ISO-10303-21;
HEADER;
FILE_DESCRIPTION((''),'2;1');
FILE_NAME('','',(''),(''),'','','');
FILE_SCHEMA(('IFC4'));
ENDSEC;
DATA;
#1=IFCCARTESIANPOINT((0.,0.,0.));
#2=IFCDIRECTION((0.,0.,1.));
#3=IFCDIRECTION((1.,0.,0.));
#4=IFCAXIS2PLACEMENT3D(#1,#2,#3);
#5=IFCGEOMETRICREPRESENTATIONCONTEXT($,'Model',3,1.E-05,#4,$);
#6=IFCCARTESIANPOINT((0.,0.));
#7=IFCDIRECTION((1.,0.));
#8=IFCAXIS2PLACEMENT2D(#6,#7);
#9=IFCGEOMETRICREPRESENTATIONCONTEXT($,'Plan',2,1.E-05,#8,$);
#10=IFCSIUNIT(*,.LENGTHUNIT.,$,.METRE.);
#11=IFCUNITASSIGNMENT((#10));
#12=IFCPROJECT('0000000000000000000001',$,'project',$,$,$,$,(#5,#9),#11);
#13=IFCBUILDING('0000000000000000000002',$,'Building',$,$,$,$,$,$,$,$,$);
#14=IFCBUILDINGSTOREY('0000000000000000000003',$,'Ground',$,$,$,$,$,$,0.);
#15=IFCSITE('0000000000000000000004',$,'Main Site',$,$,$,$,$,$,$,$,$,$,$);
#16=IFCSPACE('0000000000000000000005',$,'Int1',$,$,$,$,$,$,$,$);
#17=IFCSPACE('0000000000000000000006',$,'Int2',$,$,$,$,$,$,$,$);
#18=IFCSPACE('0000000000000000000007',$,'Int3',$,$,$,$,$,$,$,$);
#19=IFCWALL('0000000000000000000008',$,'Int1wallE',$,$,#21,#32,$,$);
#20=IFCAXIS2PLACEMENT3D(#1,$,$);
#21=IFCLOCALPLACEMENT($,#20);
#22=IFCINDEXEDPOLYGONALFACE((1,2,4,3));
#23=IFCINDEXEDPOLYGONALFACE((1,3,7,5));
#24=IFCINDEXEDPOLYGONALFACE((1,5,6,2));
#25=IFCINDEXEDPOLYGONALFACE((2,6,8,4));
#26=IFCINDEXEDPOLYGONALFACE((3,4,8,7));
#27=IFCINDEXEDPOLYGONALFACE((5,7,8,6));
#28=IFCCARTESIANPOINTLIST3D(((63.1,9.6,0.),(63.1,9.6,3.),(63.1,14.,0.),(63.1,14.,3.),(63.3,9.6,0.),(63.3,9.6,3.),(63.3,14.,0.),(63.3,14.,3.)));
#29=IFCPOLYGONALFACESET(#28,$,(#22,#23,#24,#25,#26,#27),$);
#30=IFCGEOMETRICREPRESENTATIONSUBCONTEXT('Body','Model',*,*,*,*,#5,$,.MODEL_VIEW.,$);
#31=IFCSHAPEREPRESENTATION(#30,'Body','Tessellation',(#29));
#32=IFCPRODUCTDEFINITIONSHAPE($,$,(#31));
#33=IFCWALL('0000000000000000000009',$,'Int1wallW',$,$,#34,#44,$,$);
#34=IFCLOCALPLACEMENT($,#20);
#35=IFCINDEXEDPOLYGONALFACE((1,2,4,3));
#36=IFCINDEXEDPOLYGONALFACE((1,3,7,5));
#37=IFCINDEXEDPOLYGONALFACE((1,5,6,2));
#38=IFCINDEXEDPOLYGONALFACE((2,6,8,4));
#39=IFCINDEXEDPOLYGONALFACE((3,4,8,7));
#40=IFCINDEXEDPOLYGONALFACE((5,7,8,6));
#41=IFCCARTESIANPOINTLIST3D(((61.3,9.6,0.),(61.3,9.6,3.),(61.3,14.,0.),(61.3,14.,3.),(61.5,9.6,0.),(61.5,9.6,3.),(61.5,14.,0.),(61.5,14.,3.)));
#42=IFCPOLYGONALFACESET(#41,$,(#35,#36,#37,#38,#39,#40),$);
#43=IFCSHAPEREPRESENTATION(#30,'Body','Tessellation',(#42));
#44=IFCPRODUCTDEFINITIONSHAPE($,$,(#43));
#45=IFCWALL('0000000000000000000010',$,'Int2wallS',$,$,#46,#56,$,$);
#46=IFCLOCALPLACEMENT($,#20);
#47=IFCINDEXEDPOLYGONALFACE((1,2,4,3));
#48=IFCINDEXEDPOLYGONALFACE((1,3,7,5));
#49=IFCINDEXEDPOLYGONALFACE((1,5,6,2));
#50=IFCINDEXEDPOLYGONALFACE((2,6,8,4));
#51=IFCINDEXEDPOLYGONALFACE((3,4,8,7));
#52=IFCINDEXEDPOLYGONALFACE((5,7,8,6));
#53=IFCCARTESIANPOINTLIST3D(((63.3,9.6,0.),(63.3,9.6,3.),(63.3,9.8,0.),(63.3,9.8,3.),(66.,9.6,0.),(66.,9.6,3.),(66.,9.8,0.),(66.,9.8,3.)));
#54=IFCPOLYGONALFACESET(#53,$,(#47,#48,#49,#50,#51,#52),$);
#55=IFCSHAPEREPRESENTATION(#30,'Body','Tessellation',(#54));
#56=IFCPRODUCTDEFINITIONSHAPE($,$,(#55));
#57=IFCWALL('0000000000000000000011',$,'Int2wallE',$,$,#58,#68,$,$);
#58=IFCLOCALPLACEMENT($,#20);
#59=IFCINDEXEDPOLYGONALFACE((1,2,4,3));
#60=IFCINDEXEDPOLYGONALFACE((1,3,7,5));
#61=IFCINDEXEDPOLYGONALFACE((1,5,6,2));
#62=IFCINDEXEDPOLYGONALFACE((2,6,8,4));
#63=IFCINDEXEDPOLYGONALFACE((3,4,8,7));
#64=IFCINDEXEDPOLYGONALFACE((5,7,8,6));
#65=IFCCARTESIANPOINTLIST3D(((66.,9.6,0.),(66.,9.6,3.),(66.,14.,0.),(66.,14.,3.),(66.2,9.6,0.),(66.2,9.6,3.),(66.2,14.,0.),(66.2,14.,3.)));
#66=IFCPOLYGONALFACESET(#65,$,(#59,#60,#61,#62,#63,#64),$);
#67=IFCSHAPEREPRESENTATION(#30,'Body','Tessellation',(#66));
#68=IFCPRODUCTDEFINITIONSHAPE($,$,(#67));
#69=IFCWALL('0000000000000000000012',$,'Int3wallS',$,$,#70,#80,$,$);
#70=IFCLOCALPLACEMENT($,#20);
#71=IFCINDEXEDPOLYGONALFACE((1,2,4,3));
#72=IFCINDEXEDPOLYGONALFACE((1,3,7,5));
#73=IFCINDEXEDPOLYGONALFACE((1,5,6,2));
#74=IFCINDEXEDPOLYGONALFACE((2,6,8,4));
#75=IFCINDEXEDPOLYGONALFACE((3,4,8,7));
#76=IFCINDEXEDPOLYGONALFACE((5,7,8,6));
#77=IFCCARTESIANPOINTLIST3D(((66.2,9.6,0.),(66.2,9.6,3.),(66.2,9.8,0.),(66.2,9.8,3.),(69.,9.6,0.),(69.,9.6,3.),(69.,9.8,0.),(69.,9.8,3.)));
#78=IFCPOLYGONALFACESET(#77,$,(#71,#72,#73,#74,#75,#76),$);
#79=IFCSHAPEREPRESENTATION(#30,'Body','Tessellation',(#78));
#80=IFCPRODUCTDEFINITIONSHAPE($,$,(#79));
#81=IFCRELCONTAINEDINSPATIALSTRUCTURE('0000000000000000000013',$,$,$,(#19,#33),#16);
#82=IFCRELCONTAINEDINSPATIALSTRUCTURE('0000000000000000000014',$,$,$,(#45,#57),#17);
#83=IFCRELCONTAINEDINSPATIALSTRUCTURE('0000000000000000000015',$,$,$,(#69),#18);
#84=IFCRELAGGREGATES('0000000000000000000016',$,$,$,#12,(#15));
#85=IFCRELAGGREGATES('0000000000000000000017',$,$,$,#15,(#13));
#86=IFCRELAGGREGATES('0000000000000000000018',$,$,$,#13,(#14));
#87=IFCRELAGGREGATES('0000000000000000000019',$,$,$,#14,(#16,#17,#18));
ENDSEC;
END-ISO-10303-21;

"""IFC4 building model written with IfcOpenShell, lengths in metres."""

from ifc_helpers import new_model, si_unit, frame, origin_with_axes, origin_2d_with_axis, place, context, subcontext, project, spatial, indexed_curve, outline, extrude, element, save


model = new_model("IFC4")

# Units and contexts
model_context = context("Model", 3, precision=1e-05, world=origin_with_axes())
plan_context = context("Plan", 2, precision=1e-05, world=origin_2d_with_axis())
body_context = subcontext(model_context, "Body", "Model", "MODEL_VIEW")
ifc_project = project(units=[si_unit("LENGTHUNIT", "METRE")], contexts=[model_context, plan_context])

# Site, building, storey
site = spatial("IfcSite", under=ifc_project, Name="Main Site")
building = spatial("IfcBuilding", under=site, Name="Building")
storey = spatial("IfcBuildingStorey", under=building, Name="Ground", Elevation=0.0)

# Shared definitions
space_1 = spatial("IfcSpace", under=storey, Name="Int1")

# Walls
for number, where, z_axis, x_axis, name in (
    (1, (63.3, 9.6, 0.0), (0.0, 0.0, 1.0), (0.0, 1.0, 0.0), "Int1wallE"),
    (2, (61.5, 9.6, 0.0), (0.0, 0.0, 1.0), (0.0, 1.0, 0.0), "Int1wallW"),
):
    element("IfcWall", number, at=place(None, frame(where, z_axis=z_axis, x_axis=x_axis)), inside=space_1, Name=name, context=body_context, shape_type="SweptSolid", body=[
        extrude(outline(indexed_curve([(0.0, 0.0), (0.0, 0.2), (4.4, 0.2), (4.4, 0.0), (0.0, 0.0)], self_intersect=False)), origin_with_axes(), (0.0, 0.0, 1.0), 3.0),
    ])

# Shared definitions
space_2 = spatial("IfcSpace", under=storey, Name="Int2")

# Walls
wall_1_placement = place(None, frame((63.3, 9.6, 0.0), z_axis=(0.0, 0.0, 1.0), x_axis=(1.0, 0.0, 0.0)))
element("IfcWall", 3, at=wall_1_placement, inside=space_2, Name="Int2wallS", context=body_context, shape_type="SweptSolid", body=[
    extrude(outline(indexed_curve([(0.0, 0.0), (0.0, 0.2), (2.7, 0.2), (2.7, 0.0), (0.0, 0.0)], self_intersect=False)), origin_with_axes(), (0.0, 0.0, 1.0), 3.0),
])
for number, where, z_axis, x_axis, name in (
    (4, (66.2, 9.6, 0.0), (0.0, 0.0, 1.0), (0.0, 1.0, 0.0), "Int2wallE"),
):
    element("IfcWall", number, at=place(None, frame(where, z_axis=z_axis, x_axis=x_axis)), inside=space_2, Name=name, context=body_context, shape_type="SweptSolid", body=[
        extrude(outline(indexed_curve([(0.0, 0.0), (0.0, 0.2), (4.4, 0.2), (4.4, 0.0), (0.0, 0.0)], self_intersect=False)), origin_with_axes(), (0.0, 0.0, 1.0), 3.0),
    ])

# Shared definitions
space_3 = spatial("IfcSpace", under=storey, Name="Int3")

# Wall
wall_2_placement = place(None, frame((66.2, 9.6, 0.0), z_axis=(0.0, 0.0, 1.0), x_axis=(1.0, 0.0, 0.0)))
element("IfcWall", 5, at=wall_2_placement, inside=space_3, Name="Int3wallS", context=body_context, shape_type="SweptSolid", body=[
    extrude(outline(indexed_curve([(0.0, 0.0), (0.0, 0.2), (2.8, 0.2), (2.8, 0.0), (0.0, 0.0)], self_intersect=False)), origin_with_axes(), (0.0, 0.0, 1.0), 3.0),
])

save(model, "model.ifc")
